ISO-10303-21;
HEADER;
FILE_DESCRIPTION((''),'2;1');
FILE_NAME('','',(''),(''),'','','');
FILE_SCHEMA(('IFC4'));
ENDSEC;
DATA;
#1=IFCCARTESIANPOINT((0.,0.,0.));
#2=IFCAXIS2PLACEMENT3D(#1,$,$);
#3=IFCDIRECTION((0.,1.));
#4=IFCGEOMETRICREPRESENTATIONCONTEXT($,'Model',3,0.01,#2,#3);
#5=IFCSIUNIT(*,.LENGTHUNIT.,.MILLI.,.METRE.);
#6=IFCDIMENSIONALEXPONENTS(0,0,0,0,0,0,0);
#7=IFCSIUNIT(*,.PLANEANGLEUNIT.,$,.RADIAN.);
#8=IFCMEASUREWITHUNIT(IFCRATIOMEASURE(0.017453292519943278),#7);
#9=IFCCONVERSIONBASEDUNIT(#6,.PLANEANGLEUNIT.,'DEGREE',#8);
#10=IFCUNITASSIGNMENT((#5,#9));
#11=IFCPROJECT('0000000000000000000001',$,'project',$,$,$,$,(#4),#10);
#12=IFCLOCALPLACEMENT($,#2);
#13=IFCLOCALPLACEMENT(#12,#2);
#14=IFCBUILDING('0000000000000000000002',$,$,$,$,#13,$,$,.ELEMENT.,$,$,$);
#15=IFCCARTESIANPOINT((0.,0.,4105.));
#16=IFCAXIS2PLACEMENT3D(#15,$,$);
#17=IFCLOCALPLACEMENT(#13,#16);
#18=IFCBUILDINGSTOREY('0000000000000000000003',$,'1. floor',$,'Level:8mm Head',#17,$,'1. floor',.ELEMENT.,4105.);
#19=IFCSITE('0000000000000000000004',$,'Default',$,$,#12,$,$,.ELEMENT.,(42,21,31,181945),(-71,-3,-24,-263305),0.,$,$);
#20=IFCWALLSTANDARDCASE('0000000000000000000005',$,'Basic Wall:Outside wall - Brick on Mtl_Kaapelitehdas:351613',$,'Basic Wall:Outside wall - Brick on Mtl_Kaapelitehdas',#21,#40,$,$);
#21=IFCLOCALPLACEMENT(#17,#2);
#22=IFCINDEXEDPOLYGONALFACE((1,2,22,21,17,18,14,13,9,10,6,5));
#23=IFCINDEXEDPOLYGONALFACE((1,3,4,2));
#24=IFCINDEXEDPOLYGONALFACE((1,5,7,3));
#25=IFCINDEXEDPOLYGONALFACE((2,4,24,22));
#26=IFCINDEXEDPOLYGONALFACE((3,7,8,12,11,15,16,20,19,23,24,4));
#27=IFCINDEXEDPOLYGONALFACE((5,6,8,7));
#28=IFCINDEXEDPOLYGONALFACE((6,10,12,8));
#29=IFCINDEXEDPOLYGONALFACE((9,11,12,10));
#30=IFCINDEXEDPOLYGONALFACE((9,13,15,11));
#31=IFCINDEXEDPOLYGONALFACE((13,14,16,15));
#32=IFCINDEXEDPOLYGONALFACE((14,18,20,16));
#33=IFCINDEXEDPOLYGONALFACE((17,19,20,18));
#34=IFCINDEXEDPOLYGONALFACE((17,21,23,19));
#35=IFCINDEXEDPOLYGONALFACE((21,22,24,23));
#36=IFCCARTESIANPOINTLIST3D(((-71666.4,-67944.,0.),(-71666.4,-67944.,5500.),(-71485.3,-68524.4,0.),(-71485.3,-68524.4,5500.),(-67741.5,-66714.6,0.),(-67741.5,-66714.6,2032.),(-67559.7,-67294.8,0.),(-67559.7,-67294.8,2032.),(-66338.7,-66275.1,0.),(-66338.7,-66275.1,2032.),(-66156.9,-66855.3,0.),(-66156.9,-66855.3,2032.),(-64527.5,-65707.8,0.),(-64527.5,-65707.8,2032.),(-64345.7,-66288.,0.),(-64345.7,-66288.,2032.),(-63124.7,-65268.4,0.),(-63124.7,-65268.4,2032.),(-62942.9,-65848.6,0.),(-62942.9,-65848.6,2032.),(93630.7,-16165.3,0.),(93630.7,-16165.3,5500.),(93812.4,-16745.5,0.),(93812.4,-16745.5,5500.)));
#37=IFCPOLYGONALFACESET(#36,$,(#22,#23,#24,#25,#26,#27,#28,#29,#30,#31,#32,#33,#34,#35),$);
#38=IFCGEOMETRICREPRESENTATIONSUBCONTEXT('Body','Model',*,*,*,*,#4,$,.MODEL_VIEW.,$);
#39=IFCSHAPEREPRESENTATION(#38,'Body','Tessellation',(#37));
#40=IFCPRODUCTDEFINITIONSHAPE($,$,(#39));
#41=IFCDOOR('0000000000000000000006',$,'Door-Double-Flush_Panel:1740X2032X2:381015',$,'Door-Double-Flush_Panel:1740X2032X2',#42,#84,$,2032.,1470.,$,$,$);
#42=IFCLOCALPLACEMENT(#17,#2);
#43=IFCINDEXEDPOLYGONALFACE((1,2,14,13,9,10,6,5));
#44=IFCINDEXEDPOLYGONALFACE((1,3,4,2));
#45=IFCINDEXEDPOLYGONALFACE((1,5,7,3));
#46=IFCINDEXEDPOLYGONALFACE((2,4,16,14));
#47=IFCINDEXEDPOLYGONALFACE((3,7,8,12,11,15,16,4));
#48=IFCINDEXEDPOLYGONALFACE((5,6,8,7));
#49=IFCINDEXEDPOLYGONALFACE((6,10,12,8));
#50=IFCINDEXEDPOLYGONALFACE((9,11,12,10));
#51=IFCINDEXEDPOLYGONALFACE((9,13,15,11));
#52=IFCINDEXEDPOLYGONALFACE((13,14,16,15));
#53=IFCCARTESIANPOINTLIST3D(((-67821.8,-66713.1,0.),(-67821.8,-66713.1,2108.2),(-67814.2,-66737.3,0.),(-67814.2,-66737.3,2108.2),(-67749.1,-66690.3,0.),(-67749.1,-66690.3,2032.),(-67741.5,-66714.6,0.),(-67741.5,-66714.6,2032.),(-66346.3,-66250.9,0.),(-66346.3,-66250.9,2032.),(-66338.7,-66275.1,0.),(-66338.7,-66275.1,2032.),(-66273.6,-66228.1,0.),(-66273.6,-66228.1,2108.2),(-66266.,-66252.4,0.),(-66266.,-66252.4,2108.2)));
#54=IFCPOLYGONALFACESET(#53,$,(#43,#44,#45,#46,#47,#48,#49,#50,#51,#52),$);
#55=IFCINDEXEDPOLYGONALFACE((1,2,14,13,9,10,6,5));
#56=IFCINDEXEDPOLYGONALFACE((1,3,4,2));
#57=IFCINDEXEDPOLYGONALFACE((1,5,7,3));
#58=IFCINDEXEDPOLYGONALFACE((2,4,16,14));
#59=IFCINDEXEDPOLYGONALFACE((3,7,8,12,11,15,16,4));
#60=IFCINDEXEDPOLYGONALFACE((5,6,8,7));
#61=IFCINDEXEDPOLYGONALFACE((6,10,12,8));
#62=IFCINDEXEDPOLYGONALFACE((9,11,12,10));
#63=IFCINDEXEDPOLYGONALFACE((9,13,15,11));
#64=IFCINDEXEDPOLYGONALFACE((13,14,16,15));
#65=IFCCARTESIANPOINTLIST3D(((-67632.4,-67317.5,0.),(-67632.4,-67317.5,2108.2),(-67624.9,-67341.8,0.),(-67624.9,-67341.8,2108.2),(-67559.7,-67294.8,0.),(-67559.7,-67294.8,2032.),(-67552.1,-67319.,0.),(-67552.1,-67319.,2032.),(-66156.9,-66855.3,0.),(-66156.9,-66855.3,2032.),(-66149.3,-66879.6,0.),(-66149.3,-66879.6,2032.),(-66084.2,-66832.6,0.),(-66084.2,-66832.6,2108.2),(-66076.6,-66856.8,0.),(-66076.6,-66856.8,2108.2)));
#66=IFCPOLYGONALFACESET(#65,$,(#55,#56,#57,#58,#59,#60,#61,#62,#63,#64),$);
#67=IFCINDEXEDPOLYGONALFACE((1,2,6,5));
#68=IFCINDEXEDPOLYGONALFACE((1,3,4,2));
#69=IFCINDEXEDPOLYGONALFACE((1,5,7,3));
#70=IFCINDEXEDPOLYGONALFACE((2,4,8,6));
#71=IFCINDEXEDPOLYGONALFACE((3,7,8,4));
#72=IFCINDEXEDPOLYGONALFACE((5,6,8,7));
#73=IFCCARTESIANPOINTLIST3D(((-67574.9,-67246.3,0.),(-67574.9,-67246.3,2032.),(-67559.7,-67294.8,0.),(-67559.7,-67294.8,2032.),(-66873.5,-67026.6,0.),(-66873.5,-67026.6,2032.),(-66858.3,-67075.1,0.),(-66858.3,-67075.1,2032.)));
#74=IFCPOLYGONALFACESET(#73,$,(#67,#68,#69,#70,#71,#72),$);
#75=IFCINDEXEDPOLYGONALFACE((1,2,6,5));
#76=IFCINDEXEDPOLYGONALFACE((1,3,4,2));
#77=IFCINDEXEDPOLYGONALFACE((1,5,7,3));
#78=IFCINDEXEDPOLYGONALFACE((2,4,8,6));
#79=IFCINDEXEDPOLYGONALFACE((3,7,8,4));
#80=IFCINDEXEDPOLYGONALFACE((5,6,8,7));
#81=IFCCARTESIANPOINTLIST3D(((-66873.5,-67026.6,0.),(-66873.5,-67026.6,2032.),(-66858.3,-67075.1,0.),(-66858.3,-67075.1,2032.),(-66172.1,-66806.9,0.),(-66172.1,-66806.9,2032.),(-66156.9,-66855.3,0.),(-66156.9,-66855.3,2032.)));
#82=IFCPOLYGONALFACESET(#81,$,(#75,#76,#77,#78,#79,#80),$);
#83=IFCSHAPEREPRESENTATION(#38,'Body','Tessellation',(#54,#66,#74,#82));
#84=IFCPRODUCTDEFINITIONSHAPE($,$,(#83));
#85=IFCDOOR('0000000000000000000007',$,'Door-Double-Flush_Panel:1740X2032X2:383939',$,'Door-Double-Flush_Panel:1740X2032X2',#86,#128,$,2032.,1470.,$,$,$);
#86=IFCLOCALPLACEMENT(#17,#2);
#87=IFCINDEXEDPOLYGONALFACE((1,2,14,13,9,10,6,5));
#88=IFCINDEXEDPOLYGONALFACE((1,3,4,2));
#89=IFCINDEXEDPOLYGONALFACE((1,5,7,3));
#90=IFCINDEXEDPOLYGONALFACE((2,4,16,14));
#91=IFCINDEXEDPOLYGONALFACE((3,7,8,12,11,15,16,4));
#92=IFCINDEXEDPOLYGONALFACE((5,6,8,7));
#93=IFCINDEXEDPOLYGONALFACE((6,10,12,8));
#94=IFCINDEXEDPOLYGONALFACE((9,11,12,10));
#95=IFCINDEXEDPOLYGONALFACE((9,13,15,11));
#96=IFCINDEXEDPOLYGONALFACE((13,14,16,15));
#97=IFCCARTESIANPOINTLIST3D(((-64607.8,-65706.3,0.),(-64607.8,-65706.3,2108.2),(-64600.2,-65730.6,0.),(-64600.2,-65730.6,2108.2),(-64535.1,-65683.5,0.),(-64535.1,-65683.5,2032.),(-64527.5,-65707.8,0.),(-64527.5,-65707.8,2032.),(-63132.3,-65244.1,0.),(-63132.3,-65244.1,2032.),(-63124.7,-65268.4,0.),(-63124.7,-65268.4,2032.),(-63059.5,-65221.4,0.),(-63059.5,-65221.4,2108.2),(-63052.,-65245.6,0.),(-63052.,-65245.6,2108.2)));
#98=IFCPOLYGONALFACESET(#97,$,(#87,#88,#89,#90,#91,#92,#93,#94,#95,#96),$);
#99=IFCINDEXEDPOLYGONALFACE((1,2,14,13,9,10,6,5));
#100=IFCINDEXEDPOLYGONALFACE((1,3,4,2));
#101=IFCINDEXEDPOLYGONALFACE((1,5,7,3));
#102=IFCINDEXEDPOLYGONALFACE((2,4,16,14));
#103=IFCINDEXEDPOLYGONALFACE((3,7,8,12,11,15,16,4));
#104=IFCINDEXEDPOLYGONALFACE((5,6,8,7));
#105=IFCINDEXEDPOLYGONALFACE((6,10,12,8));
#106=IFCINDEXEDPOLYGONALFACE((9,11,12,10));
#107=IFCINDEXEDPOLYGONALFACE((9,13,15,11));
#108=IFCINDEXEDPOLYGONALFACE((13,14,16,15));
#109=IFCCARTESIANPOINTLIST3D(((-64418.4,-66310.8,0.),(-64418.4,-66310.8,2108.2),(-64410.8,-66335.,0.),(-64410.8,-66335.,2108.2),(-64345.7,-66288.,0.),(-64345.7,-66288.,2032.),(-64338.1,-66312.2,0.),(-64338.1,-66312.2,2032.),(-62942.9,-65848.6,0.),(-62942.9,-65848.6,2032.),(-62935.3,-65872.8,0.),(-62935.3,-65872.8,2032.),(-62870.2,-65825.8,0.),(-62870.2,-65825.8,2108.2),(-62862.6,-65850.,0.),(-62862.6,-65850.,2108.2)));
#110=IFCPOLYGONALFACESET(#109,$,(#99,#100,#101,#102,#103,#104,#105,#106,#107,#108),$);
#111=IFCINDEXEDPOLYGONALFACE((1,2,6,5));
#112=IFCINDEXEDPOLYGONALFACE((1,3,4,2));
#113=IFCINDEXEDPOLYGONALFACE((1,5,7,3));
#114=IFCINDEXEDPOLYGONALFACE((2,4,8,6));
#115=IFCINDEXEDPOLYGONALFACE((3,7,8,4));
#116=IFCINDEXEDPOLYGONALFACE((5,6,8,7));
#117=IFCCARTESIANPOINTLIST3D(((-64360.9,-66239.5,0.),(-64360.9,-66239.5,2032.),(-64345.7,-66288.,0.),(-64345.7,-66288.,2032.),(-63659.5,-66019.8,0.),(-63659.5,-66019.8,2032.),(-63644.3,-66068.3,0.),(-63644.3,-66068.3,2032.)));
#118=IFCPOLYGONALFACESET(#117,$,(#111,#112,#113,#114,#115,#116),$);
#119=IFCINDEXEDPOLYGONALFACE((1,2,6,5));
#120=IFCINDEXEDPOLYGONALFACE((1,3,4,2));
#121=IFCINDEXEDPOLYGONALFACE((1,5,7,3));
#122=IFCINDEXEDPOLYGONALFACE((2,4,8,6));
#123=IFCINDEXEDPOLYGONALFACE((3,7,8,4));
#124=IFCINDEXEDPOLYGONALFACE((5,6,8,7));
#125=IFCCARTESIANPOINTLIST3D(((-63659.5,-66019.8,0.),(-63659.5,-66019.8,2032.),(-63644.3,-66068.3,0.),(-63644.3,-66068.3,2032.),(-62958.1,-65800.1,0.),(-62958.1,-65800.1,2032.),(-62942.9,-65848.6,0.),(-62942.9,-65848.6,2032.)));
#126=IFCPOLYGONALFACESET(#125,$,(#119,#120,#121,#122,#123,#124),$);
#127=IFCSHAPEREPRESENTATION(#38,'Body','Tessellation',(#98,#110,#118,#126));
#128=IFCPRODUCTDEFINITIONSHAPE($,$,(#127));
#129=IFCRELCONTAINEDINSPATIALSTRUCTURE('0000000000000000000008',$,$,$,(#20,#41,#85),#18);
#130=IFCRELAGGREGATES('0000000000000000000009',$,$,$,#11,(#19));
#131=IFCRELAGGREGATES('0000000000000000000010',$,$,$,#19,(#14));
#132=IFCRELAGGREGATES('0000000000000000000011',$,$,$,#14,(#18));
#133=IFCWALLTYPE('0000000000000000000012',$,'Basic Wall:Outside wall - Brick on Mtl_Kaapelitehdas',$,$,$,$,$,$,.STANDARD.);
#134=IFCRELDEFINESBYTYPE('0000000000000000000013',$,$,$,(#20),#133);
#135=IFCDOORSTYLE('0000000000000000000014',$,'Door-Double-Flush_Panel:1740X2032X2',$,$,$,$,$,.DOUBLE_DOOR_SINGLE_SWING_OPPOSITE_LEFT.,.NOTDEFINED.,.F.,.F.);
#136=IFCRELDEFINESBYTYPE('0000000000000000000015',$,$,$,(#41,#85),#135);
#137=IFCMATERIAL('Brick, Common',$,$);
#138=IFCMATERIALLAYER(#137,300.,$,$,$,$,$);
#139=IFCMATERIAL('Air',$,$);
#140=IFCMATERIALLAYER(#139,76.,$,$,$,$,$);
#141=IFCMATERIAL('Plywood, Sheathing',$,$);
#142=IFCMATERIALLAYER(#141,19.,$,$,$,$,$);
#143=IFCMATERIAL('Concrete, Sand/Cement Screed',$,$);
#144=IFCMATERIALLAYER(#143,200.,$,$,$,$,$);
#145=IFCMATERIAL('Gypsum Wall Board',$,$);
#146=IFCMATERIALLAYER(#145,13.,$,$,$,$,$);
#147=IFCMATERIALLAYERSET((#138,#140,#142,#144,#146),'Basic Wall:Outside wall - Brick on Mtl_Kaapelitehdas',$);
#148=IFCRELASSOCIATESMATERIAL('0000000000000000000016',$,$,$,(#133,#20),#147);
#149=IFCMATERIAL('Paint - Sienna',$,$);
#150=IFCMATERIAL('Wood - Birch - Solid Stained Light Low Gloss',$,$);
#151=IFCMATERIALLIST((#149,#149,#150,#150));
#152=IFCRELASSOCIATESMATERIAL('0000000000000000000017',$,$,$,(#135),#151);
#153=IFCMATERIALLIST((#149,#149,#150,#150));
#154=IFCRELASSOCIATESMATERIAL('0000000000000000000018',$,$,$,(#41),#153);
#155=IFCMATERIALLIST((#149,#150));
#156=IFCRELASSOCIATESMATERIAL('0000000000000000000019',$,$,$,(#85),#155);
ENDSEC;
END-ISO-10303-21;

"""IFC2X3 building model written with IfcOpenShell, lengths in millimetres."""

from ifc_helpers import new_model, entity, si_unit, converted_unit, direction, frame, frame_2d, origin, origin_2d_with_axis, place, context, subcontext, project, spatial, polyline, rectangle, outline, extrude, source, transform, mapped, material, material_list, layer, layer_set, layer_usage, type_object, type_shapes, element, fill, save


model = new_model("IFC2X3")

# Units and contexts
model_context = context("Model", 3, precision=0.01, world=origin(), true_north=direction((0.0, 1.0)))
body_context = subcontext(model_context, "Body", "Model", "MODEL_VIEW")
ifc_project = project(units=[si_unit("LENGTHUNIT", "METRE", prefix="MILLI"), converted_unit("PLANEANGLEUNIT", "DEGREE", entity("IfcRatioMeasure", 0.017453292519943278), si_unit("PLANEANGLEUNIT", "RADIAN"), dimensions=[0, 0, 0, 0, 0, 0, 0])], contexts=[model_context])

# Site, building, storey
site_placement = place(None, origin())
site = spatial("IfcSite", under=ifc_project, at=site_placement, Name="Default", CompositionType="ELEMENT", RefLatitude=(42, 21, 31, 181945), RefLongitude=(-71, -3, -24, -263305), RefElevation=0.0)
building_placement = place(site_placement, origin())
building = spatial("IfcBuilding", under=site, at=building_placement, CompositionType="ELEMENT")
storey_placement = place(building_placement, frame((0.0, 0.0, 4105.0)))
storey = spatial("IfcBuildingStorey", under=building, at=storey_placement, Name="1. floor", ObjectType="Level:8mm Head", LongName="1. floor", CompositionType="ELEMENT", Elevation=4105.0)

# Wall, openings, doors
ifc_material_1 = material(Name="Brick, Common")
ifc_layer_1 = layer(ifc_material_1, 300.0)
ifc_material_2 = material(Name="Air")
ifc_layer_2 = layer(ifc_material_2, 76.0)
ifc_material_3 = material(Name="Plywood, Sheathing")
ifc_layer_3 = layer(ifc_material_3, 19.0)
ifc_material_4 = material(Name="Concrete, Sand/Cement Screed")
ifc_layer_4 = layer(ifc_material_4, 200.0)
ifc_material_5 = material(Name="Gypsum Wall Board")
ifc_layer_5 = layer(ifc_material_5, 13.0)
ifc_layer_set_1 = layer_set([ifc_layer_1, ifc_layer_2, ifc_layer_3, ifc_layer_4, ifc_layer_5], Name="Basic Wall:Outside wall - Brick on Mtl_Kaapelitehdas")
ifc_layer_usage_1 = layer_usage(ifc_layer_set_1, "AXIS2", "NEGATIVE", 304.0)
wall_type_1 = type_object("IfcWallType", Name="Basic Wall:Outside wall - Brick on Mtl_Kaapelitehdas", PredefinedType="STANDARD", material=ifc_layer_set_1)
wall_1_placement = place(storey_placement, frame((93721.6, -16455.4, 0.0), z_axis=(0.0, 0.0, 1.0), x_axis=(-0.954277, -0.298924, 0.0)))
wall_1 = element("IfcWallStandardCase", 1, at=wall_1_placement, inside=storey, type_object=wall_type_1, material=ifc_layer_usage_1, Name="Basic Wall:Outside wall - Brick on Mtl_Kaapelitehdas:351613", ObjectType="Basic Wall:Outside wall - Brick on Mtl_Kaapelitehdas", context=body_context, shape_type="SweptSolid", body=[
    extrude(outline(polyline([(0.0, -304.0), (608.0, -304.0), (163156.9, -304.0), (163280.9, -304.0), (169244.1, -304.0), (169704.1, -304.0), (172609.1, -304.0), (173217.1, -304.0), (173217.8, 304.0), (0.0, 304.0), (0.0, -304.0)])), origin(), (0.0, 0.0, 1.0), 5500.0),
])
opening_1_placement = place(wall_1_placement, frame((167634.1, -304.0, 0.0)))
opening_1 = element("IfcOpeningElement", 2, at=opening_1_placement, cuts=wall_1, ObjectType="Opening", context=body_context, shape_type="SweptSolid", body=[
    extrude(rectangle(XDim=2032.0, YDim=1470.0, at=frame_2d((1016.0, 735.0), x_axis=(1.0, 0.0))), frame((0.0, 0.0, 0.0), z_axis=(0.0, 1.0, 0.0), x_axis=(0.0, 0.0, 1.0)), (0.0, 0.0, 1.0), 608.0),
])
opening_2_placement = place(wall_1_placement, frame((164266.1, -304.0, 0.0)))
opening_2 = element("IfcOpeningElement", 3, at=opening_2_placement, cuts=wall_1, ObjectType="Opening", context=body_context, shape_type="SweptSolid", body=[
    extrude(rectangle(XDim=2032.0, YDim=1470.0, at=frame_2d((1016.0, 735.0), x_axis=(1.0, 0.0))), frame((0.0, 0.0, 0.0), z_axis=(0.0, 1.0, 0.0), x_axis=(0.0, 0.0, 1.0)), (0.0, 0.0, 1.0), 608.0),
])
ifc_material_6 = material(Name="Paint - Sienna")
ifc_material_7 = material(Name="Wood - Birch - Solid Stained Light Low Gloss")
ifc_material_list_1 = material_list([ifc_material_6, ifc_material_6, ifc_material_7, ifc_material_7])
ifc_material_list_2 = material_list([ifc_material_6, ifc_material_6, ifc_material_7, ifc_material_7])
door_style_1 = type_object("IfcDoorStyle", Name="Door-Double-Flush_Panel:1740X2032X2", ConstructionType="NOTDEFINED", OperationType="DOUBLE_DOOR_SINGLE_SWING_OPPOSITE_LEFT", ParameterTakesPrecedence=False, Sizeable=False, material=ifc_material_list_2)
shared_shape_1 = source(origin(), body_context, "Body", "SweptSolid", [
    extrude(outline(polyline([(-996.9, 735.0), (1035.0, 735.0), (1035.0, 811.2), (-1073.1, 811.2), (-1073.1, -811.2), (1035.0, -811.2), (1035.0, -735.0), (-996.9, -735.0), (-996.9, 735.0)])), frame((735.0, -25.4, 1035.0), z_axis=(0.0, 1.0, 0.0), x_axis=(0.0, 0.0, -1.0)), (0.0, 0.0, 1.0), 25.4),
    extrude(outline(polyline([(-996.9, 735.0), (1035.0, 735.0), (1035.0, 811.2), (-1073.1, 811.2), (-1073.1, -811.2), (1035.0, -811.2), (1035.0, -735.0), (-996.9, -735.0), (-996.9, 735.0)])), frame((735.0, 608.0, 1035.0), z_axis=(0.0, 1.0, 0.0), x_axis=(0.0, 0.0, -1.0)), (0.0, 0.0, 1.0), 25.4),
    extrude(rectangle(XDim=50.8, YDim=735.0, at=origin_2d_with_axis()), frame((1102.5, 582.6, 0.0), z_axis=(0.0, 0.0, 1.0), x_axis=(0.0, -1.0, 0.0)), (0.0, 0.0, 1.0), 2032.0),
    extrude(rectangle(XDim=50.8, YDim=735.0, at=frame_2d((0.0, 0.0), x_axis=(1.0, 0.0))), frame((367.5, 582.6, 0.0), z_axis=(0.0, 0.0, 1.0), x_axis=(0.0, -1.0, 0.0)), (0.0, 0.0, 1.0), 2032.0),
])
type_shapes(door_style_1, [shared_shape_1])
door_1_placement = place(opening_1_placement, origin())
door_1 = element("IfcDoor", 4, at=door_1_placement, inside=storey, type_object=door_style_1, material=ifc_material_list_1, Name="Door-Double-Flush_Panel:1740X2032X2:381015", ObjectType="Door-Double-Flush_Panel:1740X2032X2", OverallHeight=2032.0, OverallWidth=1470.0, context=body_context, shape_type="MappedRepresentation", body=[
    mapped(shared_shape_1, transform((0.0, 0.0, 0.0), scale=1.0)),
])
fill(opening_1, door_1)
ifc_material_list_3 = material_list([ifc_material_6, ifc_material_7])
door_2_placement = place(opening_2_placement, origin())
door_2 = element("IfcDoor", 5, at=door_2_placement, inside=storey, type_object=door_style_1, material=ifc_material_list_3, Name="Door-Double-Flush_Panel:1740X2032X2:383939", ObjectType="Door-Double-Flush_Panel:1740X2032X2", OverallHeight=2032.0, OverallWidth=1470.0, context=body_context, shape_type="MappedRepresentation", body=[
    mapped(shared_shape_1, transform((0.0, 0.0, 0.0), scale=1.0)),
])
fill(opening_2, door_2)

save(model, "model.ifc")
